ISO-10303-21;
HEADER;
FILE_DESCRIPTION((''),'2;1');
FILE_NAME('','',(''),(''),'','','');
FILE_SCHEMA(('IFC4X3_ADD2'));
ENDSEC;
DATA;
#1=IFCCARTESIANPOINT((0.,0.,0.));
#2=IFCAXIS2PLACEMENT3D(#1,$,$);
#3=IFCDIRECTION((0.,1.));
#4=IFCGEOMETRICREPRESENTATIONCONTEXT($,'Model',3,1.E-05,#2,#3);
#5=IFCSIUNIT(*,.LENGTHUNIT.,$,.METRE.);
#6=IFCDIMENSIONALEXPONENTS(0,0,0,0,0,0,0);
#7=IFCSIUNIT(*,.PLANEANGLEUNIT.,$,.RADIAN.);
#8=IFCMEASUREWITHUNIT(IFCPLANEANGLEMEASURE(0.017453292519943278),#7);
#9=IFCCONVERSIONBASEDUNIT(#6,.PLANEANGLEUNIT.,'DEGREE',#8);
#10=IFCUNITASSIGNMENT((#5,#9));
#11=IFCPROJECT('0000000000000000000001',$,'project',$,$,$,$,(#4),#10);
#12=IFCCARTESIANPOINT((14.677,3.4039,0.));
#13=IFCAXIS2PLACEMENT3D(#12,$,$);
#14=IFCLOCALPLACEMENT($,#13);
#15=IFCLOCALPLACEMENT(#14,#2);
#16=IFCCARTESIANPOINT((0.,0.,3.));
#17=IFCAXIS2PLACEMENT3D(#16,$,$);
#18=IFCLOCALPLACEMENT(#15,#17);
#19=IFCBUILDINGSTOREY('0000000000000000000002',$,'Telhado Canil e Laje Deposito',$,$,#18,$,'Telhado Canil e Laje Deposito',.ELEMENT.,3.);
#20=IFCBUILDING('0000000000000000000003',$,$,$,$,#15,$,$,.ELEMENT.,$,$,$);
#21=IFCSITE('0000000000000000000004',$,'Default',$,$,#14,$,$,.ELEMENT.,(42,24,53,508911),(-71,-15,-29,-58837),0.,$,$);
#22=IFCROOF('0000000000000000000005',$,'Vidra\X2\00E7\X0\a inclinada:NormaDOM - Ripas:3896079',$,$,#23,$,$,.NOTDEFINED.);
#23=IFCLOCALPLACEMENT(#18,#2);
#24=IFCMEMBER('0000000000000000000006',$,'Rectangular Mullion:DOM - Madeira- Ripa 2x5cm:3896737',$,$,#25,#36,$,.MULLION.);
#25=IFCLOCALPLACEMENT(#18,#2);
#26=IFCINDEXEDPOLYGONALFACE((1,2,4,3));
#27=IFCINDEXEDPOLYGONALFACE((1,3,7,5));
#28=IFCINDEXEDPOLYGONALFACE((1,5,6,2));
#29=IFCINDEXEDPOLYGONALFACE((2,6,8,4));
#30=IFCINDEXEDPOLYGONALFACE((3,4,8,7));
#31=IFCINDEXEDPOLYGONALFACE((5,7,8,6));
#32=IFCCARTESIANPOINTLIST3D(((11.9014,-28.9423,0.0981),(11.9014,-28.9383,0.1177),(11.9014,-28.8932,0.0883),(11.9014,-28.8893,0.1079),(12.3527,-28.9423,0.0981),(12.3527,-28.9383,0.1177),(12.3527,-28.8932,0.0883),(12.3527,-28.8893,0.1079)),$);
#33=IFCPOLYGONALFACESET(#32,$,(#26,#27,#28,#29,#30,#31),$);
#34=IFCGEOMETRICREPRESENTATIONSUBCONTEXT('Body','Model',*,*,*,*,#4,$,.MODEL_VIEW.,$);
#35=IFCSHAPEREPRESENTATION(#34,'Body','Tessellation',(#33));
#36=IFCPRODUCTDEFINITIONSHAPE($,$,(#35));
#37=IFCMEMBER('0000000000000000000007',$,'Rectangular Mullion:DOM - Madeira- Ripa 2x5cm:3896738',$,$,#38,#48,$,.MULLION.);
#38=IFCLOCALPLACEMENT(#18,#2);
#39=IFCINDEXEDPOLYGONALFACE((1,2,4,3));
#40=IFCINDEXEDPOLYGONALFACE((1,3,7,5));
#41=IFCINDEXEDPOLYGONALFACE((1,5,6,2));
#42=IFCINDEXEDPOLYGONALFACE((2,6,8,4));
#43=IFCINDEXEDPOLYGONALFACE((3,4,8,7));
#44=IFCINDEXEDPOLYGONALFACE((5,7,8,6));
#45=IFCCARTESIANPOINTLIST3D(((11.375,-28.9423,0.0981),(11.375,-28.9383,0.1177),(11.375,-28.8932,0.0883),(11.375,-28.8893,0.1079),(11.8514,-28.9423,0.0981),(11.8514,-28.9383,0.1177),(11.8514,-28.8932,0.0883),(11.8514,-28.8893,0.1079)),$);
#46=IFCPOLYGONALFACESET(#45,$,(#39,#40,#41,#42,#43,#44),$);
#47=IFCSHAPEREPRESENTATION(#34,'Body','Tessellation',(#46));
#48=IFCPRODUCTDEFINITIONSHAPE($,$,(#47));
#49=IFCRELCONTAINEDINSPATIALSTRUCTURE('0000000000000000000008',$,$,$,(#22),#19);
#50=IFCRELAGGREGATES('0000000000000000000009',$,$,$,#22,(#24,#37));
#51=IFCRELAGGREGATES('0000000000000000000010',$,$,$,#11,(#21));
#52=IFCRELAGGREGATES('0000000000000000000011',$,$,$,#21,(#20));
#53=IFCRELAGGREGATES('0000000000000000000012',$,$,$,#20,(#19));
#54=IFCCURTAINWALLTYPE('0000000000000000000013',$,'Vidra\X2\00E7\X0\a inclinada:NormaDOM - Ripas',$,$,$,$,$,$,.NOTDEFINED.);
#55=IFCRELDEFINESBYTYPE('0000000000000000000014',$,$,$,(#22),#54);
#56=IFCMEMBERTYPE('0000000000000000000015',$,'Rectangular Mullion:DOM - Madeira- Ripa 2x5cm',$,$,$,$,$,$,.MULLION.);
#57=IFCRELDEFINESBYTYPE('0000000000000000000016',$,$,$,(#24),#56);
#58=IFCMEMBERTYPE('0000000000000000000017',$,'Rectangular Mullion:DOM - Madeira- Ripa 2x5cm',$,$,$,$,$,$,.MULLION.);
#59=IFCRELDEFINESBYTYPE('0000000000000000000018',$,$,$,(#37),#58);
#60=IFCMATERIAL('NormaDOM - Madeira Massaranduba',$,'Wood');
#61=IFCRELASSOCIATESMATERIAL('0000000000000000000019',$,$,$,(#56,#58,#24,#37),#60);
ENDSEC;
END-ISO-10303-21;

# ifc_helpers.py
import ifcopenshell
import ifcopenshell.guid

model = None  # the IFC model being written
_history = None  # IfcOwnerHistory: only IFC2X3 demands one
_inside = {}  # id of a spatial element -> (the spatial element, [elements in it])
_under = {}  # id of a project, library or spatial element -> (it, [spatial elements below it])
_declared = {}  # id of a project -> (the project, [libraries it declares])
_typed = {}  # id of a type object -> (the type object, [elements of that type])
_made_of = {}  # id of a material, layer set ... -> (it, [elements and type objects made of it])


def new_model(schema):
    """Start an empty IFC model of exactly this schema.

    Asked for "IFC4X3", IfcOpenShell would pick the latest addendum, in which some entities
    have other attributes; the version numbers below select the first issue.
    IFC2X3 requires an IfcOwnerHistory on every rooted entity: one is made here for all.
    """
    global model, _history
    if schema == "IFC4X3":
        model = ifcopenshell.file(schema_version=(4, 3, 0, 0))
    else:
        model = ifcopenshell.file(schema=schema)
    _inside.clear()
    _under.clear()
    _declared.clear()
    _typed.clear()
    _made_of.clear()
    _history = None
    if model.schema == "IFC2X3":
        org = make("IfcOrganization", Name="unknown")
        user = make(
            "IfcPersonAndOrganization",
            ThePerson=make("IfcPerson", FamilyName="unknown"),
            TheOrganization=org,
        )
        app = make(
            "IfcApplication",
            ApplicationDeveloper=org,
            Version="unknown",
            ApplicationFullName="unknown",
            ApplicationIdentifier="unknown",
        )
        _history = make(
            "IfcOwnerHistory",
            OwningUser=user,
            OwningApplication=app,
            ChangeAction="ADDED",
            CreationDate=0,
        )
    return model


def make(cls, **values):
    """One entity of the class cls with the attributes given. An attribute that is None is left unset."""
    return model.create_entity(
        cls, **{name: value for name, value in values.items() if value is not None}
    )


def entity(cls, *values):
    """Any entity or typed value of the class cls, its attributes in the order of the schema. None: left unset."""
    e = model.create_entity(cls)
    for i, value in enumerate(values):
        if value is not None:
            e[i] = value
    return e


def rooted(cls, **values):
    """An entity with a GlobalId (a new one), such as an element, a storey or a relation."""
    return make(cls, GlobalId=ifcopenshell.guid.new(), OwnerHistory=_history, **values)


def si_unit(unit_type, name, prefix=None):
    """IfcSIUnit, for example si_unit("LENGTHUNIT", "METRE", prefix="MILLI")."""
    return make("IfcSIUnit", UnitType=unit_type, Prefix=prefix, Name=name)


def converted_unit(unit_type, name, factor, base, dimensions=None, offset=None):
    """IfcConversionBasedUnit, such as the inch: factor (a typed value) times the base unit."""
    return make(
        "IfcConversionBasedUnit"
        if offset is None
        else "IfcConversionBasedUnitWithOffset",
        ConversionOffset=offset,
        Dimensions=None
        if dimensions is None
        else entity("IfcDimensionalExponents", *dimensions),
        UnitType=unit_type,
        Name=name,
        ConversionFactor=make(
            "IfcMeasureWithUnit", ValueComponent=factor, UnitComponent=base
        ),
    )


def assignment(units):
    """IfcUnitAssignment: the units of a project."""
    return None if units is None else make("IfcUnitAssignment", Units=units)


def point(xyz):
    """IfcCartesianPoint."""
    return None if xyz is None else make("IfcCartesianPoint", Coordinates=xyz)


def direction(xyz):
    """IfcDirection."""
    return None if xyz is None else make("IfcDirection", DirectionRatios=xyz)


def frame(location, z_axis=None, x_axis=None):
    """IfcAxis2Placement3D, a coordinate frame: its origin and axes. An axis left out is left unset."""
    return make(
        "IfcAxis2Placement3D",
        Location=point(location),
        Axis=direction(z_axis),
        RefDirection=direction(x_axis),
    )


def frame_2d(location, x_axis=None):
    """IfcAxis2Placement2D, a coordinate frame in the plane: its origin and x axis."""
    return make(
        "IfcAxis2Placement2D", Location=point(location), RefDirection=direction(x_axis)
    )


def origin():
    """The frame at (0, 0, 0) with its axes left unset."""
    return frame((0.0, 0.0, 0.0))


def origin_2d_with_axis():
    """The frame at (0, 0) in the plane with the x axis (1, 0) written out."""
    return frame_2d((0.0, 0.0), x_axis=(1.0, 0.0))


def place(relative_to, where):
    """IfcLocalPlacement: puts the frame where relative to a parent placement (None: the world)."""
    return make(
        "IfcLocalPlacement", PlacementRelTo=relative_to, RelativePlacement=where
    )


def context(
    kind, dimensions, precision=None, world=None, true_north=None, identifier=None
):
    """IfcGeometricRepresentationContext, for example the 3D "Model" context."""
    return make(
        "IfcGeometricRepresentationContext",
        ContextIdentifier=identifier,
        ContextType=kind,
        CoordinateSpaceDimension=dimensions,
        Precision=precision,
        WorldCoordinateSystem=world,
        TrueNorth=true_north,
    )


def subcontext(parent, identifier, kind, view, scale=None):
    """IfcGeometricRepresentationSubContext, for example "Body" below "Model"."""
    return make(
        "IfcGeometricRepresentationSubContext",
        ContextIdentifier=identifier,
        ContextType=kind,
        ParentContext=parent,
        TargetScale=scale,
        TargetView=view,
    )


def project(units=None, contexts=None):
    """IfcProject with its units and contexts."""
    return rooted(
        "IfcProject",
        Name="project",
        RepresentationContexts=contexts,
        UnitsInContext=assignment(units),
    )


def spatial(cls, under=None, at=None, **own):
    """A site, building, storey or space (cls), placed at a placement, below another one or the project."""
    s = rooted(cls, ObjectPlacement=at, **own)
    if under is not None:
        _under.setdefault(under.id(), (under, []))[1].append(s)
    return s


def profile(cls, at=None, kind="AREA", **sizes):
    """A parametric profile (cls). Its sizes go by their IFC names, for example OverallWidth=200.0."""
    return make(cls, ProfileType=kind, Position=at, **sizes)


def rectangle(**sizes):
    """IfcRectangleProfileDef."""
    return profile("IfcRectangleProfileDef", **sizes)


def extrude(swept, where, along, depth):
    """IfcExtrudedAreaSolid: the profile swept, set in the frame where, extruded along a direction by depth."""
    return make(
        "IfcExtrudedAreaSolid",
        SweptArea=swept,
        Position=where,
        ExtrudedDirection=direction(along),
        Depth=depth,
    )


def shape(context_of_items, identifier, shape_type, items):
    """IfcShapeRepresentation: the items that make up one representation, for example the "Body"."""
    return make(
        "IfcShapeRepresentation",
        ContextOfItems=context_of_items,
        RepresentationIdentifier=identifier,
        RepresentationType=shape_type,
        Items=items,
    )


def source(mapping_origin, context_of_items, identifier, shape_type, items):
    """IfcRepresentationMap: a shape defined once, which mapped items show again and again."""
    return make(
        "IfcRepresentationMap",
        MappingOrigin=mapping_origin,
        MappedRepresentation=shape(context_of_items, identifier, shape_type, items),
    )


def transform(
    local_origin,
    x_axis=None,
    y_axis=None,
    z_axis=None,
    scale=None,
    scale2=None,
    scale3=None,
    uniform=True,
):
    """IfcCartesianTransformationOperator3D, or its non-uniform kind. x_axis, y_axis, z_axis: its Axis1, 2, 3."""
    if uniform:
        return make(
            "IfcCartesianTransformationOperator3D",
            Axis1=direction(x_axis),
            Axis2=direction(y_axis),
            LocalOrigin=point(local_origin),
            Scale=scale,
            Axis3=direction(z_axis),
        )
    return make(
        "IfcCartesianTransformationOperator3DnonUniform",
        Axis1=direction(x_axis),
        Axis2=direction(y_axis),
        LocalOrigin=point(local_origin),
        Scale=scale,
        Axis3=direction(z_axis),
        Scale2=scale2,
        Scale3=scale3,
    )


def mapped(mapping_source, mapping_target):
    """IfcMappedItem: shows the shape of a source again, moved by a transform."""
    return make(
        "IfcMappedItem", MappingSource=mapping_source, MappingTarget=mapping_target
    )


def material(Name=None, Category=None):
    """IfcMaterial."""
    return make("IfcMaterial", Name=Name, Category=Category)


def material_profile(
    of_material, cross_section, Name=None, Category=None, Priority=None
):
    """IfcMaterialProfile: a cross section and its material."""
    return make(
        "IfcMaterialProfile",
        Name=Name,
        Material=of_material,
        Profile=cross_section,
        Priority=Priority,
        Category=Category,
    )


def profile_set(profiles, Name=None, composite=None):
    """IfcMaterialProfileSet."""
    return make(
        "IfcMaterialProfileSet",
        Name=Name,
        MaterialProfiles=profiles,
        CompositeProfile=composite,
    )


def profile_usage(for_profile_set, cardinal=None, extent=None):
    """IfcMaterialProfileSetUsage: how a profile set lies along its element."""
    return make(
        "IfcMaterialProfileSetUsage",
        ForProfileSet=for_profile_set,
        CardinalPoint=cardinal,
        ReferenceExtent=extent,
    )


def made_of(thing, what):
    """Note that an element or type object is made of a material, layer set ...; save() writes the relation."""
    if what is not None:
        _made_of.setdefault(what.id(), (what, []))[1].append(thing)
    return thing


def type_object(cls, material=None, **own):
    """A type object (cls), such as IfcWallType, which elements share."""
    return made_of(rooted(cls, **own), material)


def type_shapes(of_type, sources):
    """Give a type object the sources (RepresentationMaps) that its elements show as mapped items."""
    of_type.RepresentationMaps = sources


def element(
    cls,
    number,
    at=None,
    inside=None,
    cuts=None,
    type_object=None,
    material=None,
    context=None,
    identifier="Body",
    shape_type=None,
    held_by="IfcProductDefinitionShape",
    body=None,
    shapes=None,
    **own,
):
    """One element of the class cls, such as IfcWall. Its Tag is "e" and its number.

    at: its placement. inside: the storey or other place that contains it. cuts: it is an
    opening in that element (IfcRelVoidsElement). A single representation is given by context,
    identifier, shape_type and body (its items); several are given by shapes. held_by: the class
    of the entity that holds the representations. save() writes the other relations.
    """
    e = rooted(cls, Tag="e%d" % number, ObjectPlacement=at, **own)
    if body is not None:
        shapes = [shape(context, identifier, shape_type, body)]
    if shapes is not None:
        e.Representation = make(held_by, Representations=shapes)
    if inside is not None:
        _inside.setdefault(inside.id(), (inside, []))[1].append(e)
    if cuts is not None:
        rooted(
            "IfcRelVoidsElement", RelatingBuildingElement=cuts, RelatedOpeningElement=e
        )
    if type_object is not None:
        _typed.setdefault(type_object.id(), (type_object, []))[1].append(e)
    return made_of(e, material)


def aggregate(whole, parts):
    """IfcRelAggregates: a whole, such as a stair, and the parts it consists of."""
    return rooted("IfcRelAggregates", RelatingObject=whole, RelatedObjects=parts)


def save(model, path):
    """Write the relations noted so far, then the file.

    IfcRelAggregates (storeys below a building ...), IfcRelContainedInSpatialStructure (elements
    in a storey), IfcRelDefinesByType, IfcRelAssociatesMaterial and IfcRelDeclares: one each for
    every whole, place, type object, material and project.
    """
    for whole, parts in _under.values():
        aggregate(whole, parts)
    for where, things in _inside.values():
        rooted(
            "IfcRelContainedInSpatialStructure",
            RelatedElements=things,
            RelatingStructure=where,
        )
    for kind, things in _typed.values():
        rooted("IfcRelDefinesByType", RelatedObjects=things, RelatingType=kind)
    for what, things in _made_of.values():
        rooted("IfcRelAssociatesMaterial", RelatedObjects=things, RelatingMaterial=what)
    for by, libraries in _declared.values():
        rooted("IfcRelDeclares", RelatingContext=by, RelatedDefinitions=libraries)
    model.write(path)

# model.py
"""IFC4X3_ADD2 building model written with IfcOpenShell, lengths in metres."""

from ifc_helpers import new_model, entity, si_unit, converted_unit, direction, frame, origin, origin_2d_with_axis, place, context, subcontext, project, spatial, rectangle, extrude, source, transform, mapped, material, material_profile, profile_set, profile_usage, type_object, type_shapes, element, aggregate, save


model = new_model("IFC4X3_ADD2")

# Units and contexts
model_context = context("Model", 3, precision=1e-05, world=origin(), true_north=direction((0.0, 1.0)))
body_context = subcontext(model_context, "Body", "Model", "MODEL_VIEW")
ifc_project = project(units=[si_unit("LENGTHUNIT", "METRE"), converted_unit("PLANEANGLEUNIT", "DEGREE", entity("IfcPlaneAngleMeasure", 0.017453292519943278), si_unit("PLANEANGLEUNIT", "RADIAN"), dimensions=[0, 0, 0, 0, 0, 0, 0])], contexts=[model_context])

# Site, building, storey
site_placement = place(None, frame((14.677, 3.4039, 0.0)))
site = spatial("IfcSite", under=ifc_project, at=site_placement, Name="Default", CompositionType="ELEMENT", RefLatitude=(42, 24, 53, 508911), RefLongitude=(-71, -15, -29, -58837), RefElevation=0.0)
building_placement = place(site_placement, origin())
building = spatial("IfcBuilding", under=site, at=building_placement, CompositionType="ELEMENT")
storey_placement = place(building_placement, frame((0.0, 0.0, 3.0)))
storey = spatial("IfcBuildingStorey", under=building, at=storey_placement, Name="Telhado Canil e Laje Deposito", LongName="Telhado Canil e Laje Deposito", CompositionType="ELEMENT", Elevation=3.0)

# Roof, members
curtain_wall_type = type_object("IfcCurtainWallType", Name="Vidraça inclinada:NormaDOM - Ripas", PredefinedType="NOTDEFINED")
roof_placement = place(storey_placement, frame((0.0, 0.0, -3.0)))
roof = element("IfcRoof", 1, at=roof_placement, inside=storey, type_object=curtain_wall_type, Name="Vidraça inclinada:NormaDOM - Ripas:3896079", PredefinedType="NOTDEFINED")
ifc_material = material(Name="NormaDOM - Madeira Massaranduba", Category="Wood")
ifc_material_profile_1 = material_profile(ifc_material, rectangle(XDim=0.05, YDim=0.02, at=origin_2d_with_axis()), Name="DOM - Madeira- Ripa 2x5cm")
ifc_profile_set_1 = profile_set([ifc_material_profile_1], Name="DOM - Madeira- Ripa 2x5cm")
ifc_profile_usage_1 = profile_usage(ifc_profile_set_1)
member_type_1 = type_object("IfcMemberType", Name="Rectangular Mullion:DOM - Madeira- Ripa 2x5cm", PredefinedType="MULLION", material=ifc_profile_set_1)
shared_shape_1 = source(origin(), body_context, "Body", "SweptSolid", [
    extrude(rectangle(XDim=0.05, YDim=0.02, at=origin_2d_with_axis()), frame((0.025, 0.01, -0.4514), z_axis=(0.0, 0.0, 1.0), x_axis=(-1.0, 0.0, 0.0)), (0.0, 0.0, 1.0), 0.4514),
])
type_shapes(member_type_1, [shared_shape_1])
member_1_placement = place(roof_placement, frame((12.3527, -28.8893, 3.1079), z_axis=(1.0, 0.0, 0.0), x_axis=(0.0, -0.980581, 0.196116)))
member_1 = element("IfcMember", 2, at=member_1_placement, type_object=member_type_1, material=ifc_profile_usage_1, Name="Rectangular Mullion:DOM - Madeira- Ripa 2x5cm:3896737", PredefinedType="MULLION", context=body_context, shape_type="MappedRepresentation", body=[
    mapped(shared_shape_1, transform((0.0, 0.0, 0.0), scale=1.0)),
])
member_type_2 = type_object("IfcMemberType", Name="Rectangular Mullion:DOM - Madeira- Ripa 2x5cm", PredefinedType="MULLION", material=ifc_profile_set_1)
shared_shape_2 = source(origin(), body_context, "Body", "SweptSolid", [
    extrude(rectangle(XDim=0.05, YDim=0.02, at=origin_2d_with_axis()), frame((0.025, 0.01, -0.4764), z_axis=(0.0, 0.0, 1.0), x_axis=(-1.0, 0.0, 0.0)), (0.0, 0.0, 1.0), 0.4764),
])
type_shapes(member_type_2, [shared_shape_2])
member_2_placement = place(roof_placement, frame((11.8514, -28.8893, 3.1079), z_axis=(1.0, 0.0, 0.0), x_axis=(0.0, -0.980581, 0.196116)))
member_2 = element("IfcMember", 3, at=member_2_placement, type_object=member_type_2, material=ifc_profile_usage_1, Name="Rectangular Mullion:DOM - Madeira- Ripa 2x5cm:3896738", PredefinedType="MULLION", context=body_context, shape_type="MappedRepresentation", body=[
    mapped(shared_shape_2, transform((0.0, 0.0, 0.0), scale=1.0)),
])
aggregate(roof, [member_1, member_2])

save(model, "model.ifc")
